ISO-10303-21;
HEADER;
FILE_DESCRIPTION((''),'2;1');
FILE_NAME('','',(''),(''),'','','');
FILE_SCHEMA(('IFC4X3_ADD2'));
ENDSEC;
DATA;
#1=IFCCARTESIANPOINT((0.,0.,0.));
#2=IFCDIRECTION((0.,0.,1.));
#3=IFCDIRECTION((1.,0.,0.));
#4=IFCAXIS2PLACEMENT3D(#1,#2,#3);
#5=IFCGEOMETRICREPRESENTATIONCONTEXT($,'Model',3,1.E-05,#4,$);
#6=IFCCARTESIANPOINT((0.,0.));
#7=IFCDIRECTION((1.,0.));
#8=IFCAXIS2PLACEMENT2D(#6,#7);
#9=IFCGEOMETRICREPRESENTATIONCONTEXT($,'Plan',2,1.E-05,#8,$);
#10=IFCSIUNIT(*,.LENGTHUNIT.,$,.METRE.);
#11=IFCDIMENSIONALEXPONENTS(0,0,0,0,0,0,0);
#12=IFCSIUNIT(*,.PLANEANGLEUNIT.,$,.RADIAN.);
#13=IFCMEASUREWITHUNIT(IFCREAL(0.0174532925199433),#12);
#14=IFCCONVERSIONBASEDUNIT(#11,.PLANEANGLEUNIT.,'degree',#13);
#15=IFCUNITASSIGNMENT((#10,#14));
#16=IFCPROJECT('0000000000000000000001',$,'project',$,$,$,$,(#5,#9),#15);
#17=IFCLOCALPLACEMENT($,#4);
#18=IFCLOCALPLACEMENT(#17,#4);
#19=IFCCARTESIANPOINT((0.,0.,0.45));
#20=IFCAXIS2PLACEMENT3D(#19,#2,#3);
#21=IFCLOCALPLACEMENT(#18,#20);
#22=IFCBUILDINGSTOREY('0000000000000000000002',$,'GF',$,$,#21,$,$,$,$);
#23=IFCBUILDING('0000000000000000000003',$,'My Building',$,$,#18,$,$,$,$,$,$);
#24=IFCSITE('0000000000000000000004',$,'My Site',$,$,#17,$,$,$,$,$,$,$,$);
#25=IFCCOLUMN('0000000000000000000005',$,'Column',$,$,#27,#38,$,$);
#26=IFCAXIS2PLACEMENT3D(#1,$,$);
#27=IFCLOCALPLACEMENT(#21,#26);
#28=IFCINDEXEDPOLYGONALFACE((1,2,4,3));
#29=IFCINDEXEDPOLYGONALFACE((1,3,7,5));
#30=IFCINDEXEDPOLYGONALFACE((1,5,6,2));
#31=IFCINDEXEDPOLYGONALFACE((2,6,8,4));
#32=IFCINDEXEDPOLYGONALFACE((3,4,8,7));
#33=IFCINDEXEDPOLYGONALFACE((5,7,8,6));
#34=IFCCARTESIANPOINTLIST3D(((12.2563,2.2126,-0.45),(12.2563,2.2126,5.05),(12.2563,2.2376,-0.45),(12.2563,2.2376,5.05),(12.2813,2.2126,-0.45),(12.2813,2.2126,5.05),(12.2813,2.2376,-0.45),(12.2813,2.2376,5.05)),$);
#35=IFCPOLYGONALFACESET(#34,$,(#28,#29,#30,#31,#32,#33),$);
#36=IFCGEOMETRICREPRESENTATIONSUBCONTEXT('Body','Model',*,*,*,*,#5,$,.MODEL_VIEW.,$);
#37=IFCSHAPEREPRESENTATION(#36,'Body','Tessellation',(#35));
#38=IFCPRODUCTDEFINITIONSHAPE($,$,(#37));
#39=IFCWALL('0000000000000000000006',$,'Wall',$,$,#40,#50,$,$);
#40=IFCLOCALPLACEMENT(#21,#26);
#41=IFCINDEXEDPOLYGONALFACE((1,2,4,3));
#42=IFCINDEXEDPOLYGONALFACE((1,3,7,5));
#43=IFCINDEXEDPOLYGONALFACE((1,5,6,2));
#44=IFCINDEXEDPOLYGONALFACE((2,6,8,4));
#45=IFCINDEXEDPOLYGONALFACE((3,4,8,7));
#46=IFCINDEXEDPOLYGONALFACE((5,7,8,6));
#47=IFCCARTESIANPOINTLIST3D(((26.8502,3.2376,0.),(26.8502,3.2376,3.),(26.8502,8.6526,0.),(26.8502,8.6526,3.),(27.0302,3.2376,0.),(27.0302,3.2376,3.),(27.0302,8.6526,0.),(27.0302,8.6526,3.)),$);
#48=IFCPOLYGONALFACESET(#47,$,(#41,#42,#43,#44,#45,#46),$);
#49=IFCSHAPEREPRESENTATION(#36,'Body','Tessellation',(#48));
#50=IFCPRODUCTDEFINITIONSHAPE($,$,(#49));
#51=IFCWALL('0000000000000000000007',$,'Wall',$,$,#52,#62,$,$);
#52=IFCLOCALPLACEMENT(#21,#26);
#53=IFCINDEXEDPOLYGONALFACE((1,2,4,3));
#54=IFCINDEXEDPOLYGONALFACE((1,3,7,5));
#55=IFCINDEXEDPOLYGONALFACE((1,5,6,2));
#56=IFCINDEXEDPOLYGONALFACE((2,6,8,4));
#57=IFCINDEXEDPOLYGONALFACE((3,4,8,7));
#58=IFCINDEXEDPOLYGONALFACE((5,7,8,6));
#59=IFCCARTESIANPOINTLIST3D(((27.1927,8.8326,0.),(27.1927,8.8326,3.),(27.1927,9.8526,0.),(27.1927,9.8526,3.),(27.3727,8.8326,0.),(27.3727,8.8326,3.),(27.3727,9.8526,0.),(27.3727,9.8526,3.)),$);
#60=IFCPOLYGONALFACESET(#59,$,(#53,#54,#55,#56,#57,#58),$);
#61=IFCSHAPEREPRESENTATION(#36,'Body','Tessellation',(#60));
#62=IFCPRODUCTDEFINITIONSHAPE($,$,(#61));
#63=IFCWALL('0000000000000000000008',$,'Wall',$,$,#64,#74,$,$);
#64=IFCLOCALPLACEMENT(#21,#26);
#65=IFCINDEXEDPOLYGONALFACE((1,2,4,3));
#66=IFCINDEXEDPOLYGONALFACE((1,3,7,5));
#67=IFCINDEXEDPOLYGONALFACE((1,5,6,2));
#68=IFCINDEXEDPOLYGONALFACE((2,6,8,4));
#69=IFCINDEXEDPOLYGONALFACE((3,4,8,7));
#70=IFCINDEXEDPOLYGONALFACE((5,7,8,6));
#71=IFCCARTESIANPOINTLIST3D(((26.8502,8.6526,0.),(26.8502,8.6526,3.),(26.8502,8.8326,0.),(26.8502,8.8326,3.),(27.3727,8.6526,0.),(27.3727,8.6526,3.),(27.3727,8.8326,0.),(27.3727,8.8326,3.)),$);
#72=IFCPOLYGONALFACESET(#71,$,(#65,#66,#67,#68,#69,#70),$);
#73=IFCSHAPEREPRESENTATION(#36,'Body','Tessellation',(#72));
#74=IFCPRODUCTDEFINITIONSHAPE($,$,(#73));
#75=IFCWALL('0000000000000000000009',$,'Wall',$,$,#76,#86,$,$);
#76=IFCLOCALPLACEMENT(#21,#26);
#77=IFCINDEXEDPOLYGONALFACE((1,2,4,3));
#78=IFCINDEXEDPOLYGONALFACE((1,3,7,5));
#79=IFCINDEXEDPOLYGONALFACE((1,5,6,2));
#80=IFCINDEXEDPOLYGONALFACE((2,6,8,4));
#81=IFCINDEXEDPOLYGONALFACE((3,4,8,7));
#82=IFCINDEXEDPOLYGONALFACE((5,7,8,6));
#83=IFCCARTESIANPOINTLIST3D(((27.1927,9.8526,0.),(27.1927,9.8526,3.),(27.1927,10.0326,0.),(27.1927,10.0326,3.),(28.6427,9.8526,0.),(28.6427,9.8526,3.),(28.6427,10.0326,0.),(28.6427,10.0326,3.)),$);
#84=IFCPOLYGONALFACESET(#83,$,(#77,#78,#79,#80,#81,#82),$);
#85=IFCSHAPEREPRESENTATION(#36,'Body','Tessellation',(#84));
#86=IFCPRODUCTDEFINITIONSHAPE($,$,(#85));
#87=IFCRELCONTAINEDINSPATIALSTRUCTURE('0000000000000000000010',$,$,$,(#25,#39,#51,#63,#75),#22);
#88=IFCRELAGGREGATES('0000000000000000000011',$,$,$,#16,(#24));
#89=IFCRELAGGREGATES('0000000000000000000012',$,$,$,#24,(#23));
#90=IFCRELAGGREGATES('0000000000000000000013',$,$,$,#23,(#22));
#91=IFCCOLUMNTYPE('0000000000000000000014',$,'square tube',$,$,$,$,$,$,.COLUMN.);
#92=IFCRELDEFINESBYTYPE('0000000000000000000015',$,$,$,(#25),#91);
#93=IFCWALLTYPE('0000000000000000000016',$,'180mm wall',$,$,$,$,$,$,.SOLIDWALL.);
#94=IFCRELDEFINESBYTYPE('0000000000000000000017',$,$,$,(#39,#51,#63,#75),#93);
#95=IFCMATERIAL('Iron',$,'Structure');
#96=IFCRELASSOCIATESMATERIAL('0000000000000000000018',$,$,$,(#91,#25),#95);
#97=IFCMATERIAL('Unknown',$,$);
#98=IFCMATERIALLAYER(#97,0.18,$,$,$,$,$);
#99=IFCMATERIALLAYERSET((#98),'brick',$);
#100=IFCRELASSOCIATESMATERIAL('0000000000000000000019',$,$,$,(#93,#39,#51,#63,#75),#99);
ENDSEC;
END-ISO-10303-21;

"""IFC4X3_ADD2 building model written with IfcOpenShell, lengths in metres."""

from ifc_helpers import new_model, entity, si_unit, converted_unit, frame, origin_with_axes, origin_2d_with_axis, place, context, subcontext, project, spatial, indexed_curve, outline, extrude, material, layer, layer_set, layer_usage, material_profile, profile_set, profile_usage, type_object, element, save


model = new_model("IFC4X3_ADD2")

# Units and contexts
model_context = context("Model", 3, precision=1e-05, world=origin_with_axes())
plan_context = context("Plan", 2, precision=1e-05, world=origin_2d_with_axis())
body_context = subcontext(model_context, "Body", "Model", "MODEL_VIEW")
ifc_project = project(units=[si_unit("LENGTHUNIT", "METRE"), converted_unit("PLANEANGLEUNIT", "degree", entity("IfcReal", 0.0174532925199433), si_unit("PLANEANGLEUNIT", "RADIAN"), dimensions=[0, 0, 0, 0, 0, 0, 0])], contexts=[model_context, plan_context])

# Site, building, storey
site_placement = place(None, origin_with_axes())
site = spatial("IfcSite", under=ifc_project, at=site_placement, Name="My Site")
building_placement = place(site_placement, origin_with_axes())
building = spatial("IfcBuilding", under=site, at=building_placement, Name="My Building")
storey_placement = place(building_placement, frame((0.0, 0.0, 0.45), z_axis=(0.0, 0.0, 1.0), x_axis=(1.0, 0.0, 0.0)))
storey = spatial("IfcBuildingStorey", under=building, at=storey_placement, Name="GF")

# Column
ifc_material_1 = material(Name="Iron", Category="Structure")
ifc_material_profile = material_profile(ifc_material_1, outline(indexed_curve([(-0.0125, -0.0125), (0.0125, -0.0125), (0.0125, 0.0125), (-0.0125, 0.0125), (-0.0125, -0.0125)])))
ifc_profile_set = profile_set([ifc_material_profile])
column_type = type_object("IfcColumnType", Name="square tube", PredefinedType="COLUMN", material=ifc_profile_set)
ifc_profile_usage_1 = profile_usage(ifc_profile_set, cardinal=5)
column_1_placement = place(storey_placement, frame((12.2688, 2.2251, -0.45), z_axis=(0.0, 0.0, 1.0), x_axis=(1.0, 0.0, 0.0)))
element("IfcColumn", 1, at=column_1_placement, inside=storey, type_object=column_type, material=ifc_profile_usage_1, Name="Column", context=body_context, shape_type="SweptSolid", body=[
    extrude(outline(indexed_curve([(-0.0125, -0.0125), (0.0125, -0.0125), (0.0125, 0.0125), (-0.0125, 0.0125), (-0.0125, -0.0125)])), origin_with_axes(), (0.0, 0.0, 1.0), 5.5),
])

# Walls
ifc_material_2 = material(Name="Unknown")
ifc_layer = layer(ifc_material_2, 0.18)
ifc_layer_set = layer_set([ifc_layer], Name="brick")
ifc_layer_usage_1 = layer_usage(ifc_layer_set, "AXIS2", "POSITIVE", 0.0)
wall_type = type_object("IfcWallType", Name="180mm wall", PredefinedType="SOLIDWALL", material=ifc_layer_set)
wall_1_placement = place(storey_placement, frame((27.0302, 3.2376, 0.0), z_axis=(0.0, 0.0, 1.0), x_axis=(0.0, 1.0, 0.0)))
element("IfcWall", 2, at=wall_1_placement, inside=storey, type_object=wall_type, material=ifc_layer_usage_1, Name="Wall", context=body_context, shape_type="SweptSolid", body=[
    extrude(outline(indexed_curve([(0.0, 0.0), (0.0, 0.18), (5.415, 0.18), (5.415, 0.0), (0.0, 0.0)], self_intersect=False)), origin_with_axes(), (0.0, 0.0, 1.0), 3.0),
])
ifc_layer_usage_2 = layer_usage(ifc_layer_set, "AXIS2", "POSITIVE", 0.0)
wall_2_placement = place(storey_placement, frame((27.3727, 8.8326, 0.0), z_axis=(0.0, 0.0, 1.0), x_axis=(0.0, 1.0, 0.0)))
element("IfcWall", 3, at=wall_2_placement, inside=storey, type_object=wall_type, material=ifc_layer_usage_2, Name="Wall", context=body_context, shape_type="SweptSolid", body=[
    extrude(outline(indexed_curve([(0.0, 0.0), (0.0, 0.18), (1.02, 0.18), (1.02, 0.0), (0.0, 0.0)], self_intersect=False)), origin_with_axes(), (0.0, 0.0, 1.0), 3.0),
])
ifc_layer_usage_3 = layer_usage(ifc_layer_set, "AXIS2", "POSITIVE", 0.0)
wall_3_placement = place(storey_placement, frame((27.3727, 8.8326, 0.0), z_axis=(0.0, 0.0, 1.0), x_axis=(-1.0, 0.0, 0.0)))
element("IfcWall", 4, at=wall_3_placement, inside=storey, type_object=wall_type, material=ifc_layer_usage_3, Name="Wall", context=body_context, shape_type="SweptSolid", body=[
    extrude(outline(indexed_curve([(0.0, 0.0), (0.0, 0.18), (0.5225, 0.18), (0.5225, 0.0), (0.0, 0.0)], self_intersect=False)), origin_with_axes(), (0.0, 0.0, 1.0), 3.0),
])
ifc_layer_usage_4 = layer_usage(ifc_layer_set, "AXIS2", "POSITIVE", 0.0)
wall_4_placement = place(storey_placement, frame((28.6427, 10.0326, 0.0), z_axis=(0.0, 0.0, 1.0), x_axis=(-1.0, 0.0, 0.0)))
element("IfcWall", 5, at=wall_4_placement, inside=storey, type_object=wall_type, material=ifc_layer_usage_4, Name="Wall", context=body_context, shape_type="SweptSolid", body=[
    extrude(outline(indexed_curve([(0.0, 0.0), (0.0, 0.18), (1.45, 0.18), (1.45, 0.0), (0.0, 0.0)], self_intersect=False)), origin_with_axes(), (0.0, 0.0, 1.0), 3.0),
])

save(model, "model.ifc")
